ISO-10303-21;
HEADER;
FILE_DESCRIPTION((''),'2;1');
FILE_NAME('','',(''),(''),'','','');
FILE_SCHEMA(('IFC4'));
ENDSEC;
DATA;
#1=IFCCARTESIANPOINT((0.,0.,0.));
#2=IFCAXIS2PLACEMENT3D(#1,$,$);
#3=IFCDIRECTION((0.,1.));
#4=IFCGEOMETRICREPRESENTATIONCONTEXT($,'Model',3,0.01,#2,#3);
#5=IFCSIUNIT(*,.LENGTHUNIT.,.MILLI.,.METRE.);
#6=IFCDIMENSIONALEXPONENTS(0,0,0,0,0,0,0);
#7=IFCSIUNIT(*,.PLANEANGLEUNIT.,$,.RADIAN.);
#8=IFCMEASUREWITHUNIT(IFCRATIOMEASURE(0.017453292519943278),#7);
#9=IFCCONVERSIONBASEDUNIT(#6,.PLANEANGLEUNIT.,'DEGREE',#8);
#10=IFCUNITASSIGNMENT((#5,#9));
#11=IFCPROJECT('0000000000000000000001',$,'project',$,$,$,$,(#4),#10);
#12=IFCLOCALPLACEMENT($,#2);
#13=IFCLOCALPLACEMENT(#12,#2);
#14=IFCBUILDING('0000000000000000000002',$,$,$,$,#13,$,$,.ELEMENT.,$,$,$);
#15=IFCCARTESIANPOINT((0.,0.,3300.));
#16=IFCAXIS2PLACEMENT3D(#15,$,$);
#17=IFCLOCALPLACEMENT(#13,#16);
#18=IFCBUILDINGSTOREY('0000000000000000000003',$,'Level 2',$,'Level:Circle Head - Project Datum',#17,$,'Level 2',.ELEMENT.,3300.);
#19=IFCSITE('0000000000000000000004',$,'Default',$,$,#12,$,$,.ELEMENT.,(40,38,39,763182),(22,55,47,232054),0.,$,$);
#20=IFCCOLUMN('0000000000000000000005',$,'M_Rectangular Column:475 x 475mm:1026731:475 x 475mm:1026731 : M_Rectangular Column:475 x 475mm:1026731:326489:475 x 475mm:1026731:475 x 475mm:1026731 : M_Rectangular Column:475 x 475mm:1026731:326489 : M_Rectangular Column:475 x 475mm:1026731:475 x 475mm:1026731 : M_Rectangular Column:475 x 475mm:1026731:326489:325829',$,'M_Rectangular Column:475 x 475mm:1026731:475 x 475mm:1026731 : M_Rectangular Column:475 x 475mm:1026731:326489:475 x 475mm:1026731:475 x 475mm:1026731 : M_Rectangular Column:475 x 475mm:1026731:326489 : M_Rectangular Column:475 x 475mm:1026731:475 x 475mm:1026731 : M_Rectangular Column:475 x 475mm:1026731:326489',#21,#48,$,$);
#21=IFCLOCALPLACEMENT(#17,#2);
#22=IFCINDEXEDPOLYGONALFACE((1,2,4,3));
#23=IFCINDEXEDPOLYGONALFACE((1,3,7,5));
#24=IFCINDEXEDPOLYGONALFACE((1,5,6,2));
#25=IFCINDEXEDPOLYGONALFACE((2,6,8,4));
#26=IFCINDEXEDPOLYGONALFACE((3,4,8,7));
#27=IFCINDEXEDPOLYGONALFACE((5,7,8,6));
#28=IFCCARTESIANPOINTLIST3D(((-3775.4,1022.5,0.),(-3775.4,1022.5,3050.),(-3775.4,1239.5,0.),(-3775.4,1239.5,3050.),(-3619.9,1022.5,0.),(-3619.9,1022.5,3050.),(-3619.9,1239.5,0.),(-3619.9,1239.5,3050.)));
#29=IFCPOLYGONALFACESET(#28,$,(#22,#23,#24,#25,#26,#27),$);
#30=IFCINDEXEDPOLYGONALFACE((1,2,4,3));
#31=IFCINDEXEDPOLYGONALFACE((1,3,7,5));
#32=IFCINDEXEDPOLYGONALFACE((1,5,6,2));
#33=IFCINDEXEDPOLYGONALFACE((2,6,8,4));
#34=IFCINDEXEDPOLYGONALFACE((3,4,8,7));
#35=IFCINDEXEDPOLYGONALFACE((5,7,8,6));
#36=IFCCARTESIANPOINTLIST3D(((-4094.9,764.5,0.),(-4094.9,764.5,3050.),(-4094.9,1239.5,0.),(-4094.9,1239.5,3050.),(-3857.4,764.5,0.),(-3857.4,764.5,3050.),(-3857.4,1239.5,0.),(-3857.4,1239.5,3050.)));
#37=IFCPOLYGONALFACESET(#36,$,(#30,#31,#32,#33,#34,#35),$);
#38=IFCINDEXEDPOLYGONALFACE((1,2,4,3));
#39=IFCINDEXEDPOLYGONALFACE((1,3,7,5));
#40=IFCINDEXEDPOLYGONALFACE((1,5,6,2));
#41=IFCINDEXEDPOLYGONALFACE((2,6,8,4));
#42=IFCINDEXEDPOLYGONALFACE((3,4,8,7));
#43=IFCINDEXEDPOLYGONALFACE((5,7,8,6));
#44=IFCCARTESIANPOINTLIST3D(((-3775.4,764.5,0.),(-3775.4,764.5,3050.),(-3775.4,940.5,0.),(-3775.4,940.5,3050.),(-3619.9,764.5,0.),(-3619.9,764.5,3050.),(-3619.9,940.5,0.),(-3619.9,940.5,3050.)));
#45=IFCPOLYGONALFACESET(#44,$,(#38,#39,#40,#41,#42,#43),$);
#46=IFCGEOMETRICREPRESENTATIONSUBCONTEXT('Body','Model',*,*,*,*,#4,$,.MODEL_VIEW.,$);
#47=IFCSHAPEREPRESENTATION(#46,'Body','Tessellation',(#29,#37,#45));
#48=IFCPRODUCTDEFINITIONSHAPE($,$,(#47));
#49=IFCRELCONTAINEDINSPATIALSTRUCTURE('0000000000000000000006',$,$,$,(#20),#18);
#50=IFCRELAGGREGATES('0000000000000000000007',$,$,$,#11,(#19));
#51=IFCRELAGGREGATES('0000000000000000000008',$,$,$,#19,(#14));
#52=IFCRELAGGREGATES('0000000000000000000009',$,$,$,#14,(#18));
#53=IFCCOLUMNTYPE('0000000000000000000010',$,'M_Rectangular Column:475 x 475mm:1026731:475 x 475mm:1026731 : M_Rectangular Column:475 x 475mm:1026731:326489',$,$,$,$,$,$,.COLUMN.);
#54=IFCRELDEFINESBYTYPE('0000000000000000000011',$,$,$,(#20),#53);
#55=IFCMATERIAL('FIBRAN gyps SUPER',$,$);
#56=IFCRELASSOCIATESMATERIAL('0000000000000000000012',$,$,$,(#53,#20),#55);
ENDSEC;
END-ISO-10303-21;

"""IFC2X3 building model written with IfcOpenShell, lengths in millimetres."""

from ifc_helpers import new_model, entity, si_unit, converted_unit, direction, frame, frame_2d, origin, origin_2d_with_axis, place, context, subcontext, project, spatial, rectangle, extrude, source, transform, mapped, material, type_object, type_shapes, element, save


model = new_model("IFC2X3")

# Units and contexts
model_context = context("Model", 3, precision=0.01, world=origin(), true_north=direction((0.0, 1.0)))
body_context = subcontext(model_context, "Body", "Model", "MODEL_VIEW")
ifc_project = project(units=[si_unit("LENGTHUNIT", "METRE", prefix="MILLI"), converted_unit("PLANEANGLEUNIT", "DEGREE", entity("IfcRatioMeasure", 0.017453292519943278), si_unit("PLANEANGLEUNIT", "RADIAN"), dimensions=[0, 0, 0, 0, 0, 0, 0])], contexts=[model_context])

# Site, building, storey
site_placement = place(None, origin())
site = spatial("IfcSite", under=ifc_project, at=site_placement, Name="Default", CompositionType="ELEMENT", RefLatitude=(40, 38, 39, 763182), RefLongitude=(22, 55, 47, 232054), RefElevation=0.0)
building_placement = place(site_placement, origin())
building = spatial("IfcBuilding", under=site, at=building_placement, CompositionType="ELEMENT")
storey_placement = place(building_placement, frame((0.0, 0.0, 3300.0)))
storey = spatial("IfcBuildingStorey", under=building, at=storey_placement, Name="Level 2", ObjectType="Level:Circle Head - Project Datum", LongName="Level 2", CompositionType="ELEMENT", Elevation=3300.0)

# Column
ifc_material_1 = material(Name="FIBRAN gyps SUPER")
column_type = type_object("IfcColumnType", Name="M_Rectangular Column:475 x 475mm:1026731:475 x 475mm:1026731 : M_Rectangular Column:475 x 475mm:1026731:326489", PredefinedType="COLUMN", material=ifc_material_1)
shared_shape_1 = source(origin(), body_context, "Body", "SweptSolid", [
    extrude(rectangle(XDim=217.0, YDim=155.5, at=origin_2d_with_axis()), frame((-3697.6, 1131.0, 3300.0), z_axis=(0.0, 0.0, 1.0), x_axis=(0.0, -1.0, 0.0)), (0.0, 0.0, 1.0), 3050.0),
    extrude(rectangle(XDim=475.0, YDim=237.5, at=origin_2d_with_axis()), frame((-3976.1, 1002.0, 3300.0), z_axis=(0.0, 0.0, 1.0), x_axis=(0.0, -1.0, 0.0)), (0.0, 0.0, 1.0), 3050.0),
    extrude(rectangle(XDim=176.0, YDim=155.5, at=frame_2d((0.0, 0.0), x_axis=(1.0, 0.0))), frame((-3697.6, 852.5, 3300.0), z_axis=(0.0, 0.0, 1.0), x_axis=(0.0, -1.0, 0.0)), (0.0, 0.0, 1.0), 3050.0),
])
type_shapes(column_type, [shared_shape_1])
column_placement = place(storey_placement, frame((0.0, 0.0, -3300.0)))
element("IfcColumn", 1, at=column_placement, inside=storey, type_object=column_type, material=ifc_material_1, Name="M_Rectangular Column:475 x 475mm:1026731:475 x 475mm:1026731 : M_Rectangular Column:475 x 475mm:1026731:326489:475 x 475mm:1026731:475 x 475mm:1026731 : M_Rectangular Column:475 x 475mm:1026731:326489 : M_Rectangular Column:475 x 475mm:1026731:475 x 475mm:1026731 : M_Rectangular Column:475 x 475mm:1026731:326489:325829", ObjectType="M_Rectangular Column:475 x 475mm:1026731:475 x 475mm:1026731 : M_Rectangular Column:475 x 475mm:1026731:326489:475 x 475mm:1026731:475 x 475mm:1026731 : M_Rectangular Column:475 x 475mm:1026731:326489 : M_Rectangular Column:475 x 475mm:1026731:475 x 475mm:1026731 : M_Rectangular Column:475 x 475mm:1026731:326489", context=body_context, shape_type="MappedRepresentation", body=[
    mapped(shared_shape_1, transform((0.0, 0.0, 0.0), scale=1.0)),
])

save(model, "model.ifc")
